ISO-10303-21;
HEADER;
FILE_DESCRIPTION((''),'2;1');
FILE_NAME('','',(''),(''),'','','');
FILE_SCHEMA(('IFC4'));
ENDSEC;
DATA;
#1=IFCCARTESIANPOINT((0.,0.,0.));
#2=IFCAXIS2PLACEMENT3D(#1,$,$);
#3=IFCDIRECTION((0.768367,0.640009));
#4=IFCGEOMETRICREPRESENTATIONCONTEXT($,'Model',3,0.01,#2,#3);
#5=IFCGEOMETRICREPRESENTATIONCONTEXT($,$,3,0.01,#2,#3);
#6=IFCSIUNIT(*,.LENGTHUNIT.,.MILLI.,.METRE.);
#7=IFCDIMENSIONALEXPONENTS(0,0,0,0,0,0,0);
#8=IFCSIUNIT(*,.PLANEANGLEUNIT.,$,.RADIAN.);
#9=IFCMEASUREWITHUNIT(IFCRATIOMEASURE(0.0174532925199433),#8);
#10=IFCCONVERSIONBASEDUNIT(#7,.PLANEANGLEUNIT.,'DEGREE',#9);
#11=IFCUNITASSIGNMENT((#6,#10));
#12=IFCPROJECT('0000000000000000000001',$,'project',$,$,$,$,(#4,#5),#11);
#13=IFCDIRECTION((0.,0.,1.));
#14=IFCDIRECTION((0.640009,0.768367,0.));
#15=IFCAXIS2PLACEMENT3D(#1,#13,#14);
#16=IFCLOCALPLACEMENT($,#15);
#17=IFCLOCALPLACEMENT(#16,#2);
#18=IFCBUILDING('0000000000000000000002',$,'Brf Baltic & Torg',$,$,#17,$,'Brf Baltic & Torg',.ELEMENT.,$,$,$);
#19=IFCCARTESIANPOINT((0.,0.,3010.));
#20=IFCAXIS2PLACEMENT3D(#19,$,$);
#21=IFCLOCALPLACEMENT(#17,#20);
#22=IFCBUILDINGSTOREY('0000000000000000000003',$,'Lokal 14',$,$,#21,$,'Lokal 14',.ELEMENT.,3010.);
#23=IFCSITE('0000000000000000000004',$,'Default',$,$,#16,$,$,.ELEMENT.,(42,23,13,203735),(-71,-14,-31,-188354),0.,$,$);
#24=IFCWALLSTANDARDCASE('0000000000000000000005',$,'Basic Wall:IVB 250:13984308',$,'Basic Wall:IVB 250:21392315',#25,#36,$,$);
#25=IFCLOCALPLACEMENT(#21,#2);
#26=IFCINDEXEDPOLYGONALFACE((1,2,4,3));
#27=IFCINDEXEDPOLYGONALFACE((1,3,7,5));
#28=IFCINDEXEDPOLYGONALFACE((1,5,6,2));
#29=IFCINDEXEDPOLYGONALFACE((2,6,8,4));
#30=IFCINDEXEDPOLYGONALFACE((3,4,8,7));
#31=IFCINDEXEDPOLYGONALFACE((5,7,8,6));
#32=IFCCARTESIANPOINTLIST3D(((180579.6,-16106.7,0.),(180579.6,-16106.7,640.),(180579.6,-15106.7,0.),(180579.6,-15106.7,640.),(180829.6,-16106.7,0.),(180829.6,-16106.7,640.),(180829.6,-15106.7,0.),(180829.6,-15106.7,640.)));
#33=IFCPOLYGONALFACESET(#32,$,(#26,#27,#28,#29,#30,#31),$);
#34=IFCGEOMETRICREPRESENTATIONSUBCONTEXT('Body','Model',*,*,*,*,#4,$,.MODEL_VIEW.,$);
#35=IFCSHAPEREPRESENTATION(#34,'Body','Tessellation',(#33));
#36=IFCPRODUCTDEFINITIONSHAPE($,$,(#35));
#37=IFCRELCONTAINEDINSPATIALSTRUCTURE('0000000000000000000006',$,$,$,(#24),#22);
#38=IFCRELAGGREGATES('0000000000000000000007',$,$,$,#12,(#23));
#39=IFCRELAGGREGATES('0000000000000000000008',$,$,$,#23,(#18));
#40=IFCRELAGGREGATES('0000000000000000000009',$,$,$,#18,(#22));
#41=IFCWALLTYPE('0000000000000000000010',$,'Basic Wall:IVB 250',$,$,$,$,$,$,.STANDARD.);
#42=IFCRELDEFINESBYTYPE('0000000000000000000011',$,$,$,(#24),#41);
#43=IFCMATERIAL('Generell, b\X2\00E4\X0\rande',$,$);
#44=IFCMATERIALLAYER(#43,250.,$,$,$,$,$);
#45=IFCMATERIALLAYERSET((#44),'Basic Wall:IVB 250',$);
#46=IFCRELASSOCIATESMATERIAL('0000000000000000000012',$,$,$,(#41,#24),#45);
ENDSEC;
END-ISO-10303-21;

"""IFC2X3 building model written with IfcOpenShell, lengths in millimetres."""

from ifc_helpers import new_model, entity, si_unit, converted_unit, direction, frame, frame_2d, origin, place, context, subcontext, project, spatial, rectangle, extrude, clip, halfspace, material, layer, layer_set, layer_usage, type_object, element, save


model = new_model("IFC2X3")

# Units and contexts
model_context = context("Model", 3, precision=0.01, world=origin(), true_north=direction((0.768367, 0.640009)))
context_of_model = context(None, 3, precision=0.01, world=origin(), true_north=direction((0.768367, 0.640009)))
body_context = subcontext(model_context, "Body", "Model", "MODEL_VIEW")
ifc_project = project(units=[si_unit("LENGTHUNIT", "METRE", prefix="MILLI"), converted_unit("PLANEANGLEUNIT", "DEGREE", entity("IfcRatioMeasure", 0.0174532925199433), si_unit("PLANEANGLEUNIT", "RADIAN"), dimensions=[0, 0, 0, 0, 0, 0, 0])], contexts=[model_context, context_of_model])

# Site, building, storey
site_placement = place(None, frame((0.0, 0.0, 0.0), z_axis=(0.0, 0.0, 1.0), x_axis=(0.640009, 0.768367, 0.0)))
site = spatial("IfcSite", under=ifc_project, at=site_placement, Name="Default", CompositionType="ELEMENT", RefLatitude=(42, 23, 13, 203735), RefLongitude=(-71, -14, -31, -188354), RefElevation=0.0)
building_placement = place(site_placement, origin())
building = spatial("IfcBuilding", under=site, at=building_placement, Name="Brf Baltic & Torg", LongName="Brf Baltic & Torg", CompositionType="ELEMENT")
storey_placement = place(building_placement, frame((0.0, 0.0, 3010.0)))
storey = spatial("IfcBuildingStorey", under=building, at=storey_placement, Name="Lokal 14", LongName="Lokal 14", CompositionType="ELEMENT", Elevation=3010.0)

# Shared definitions
ifc_material_1 = material(Name="Generell, bärande")

# Wall
ifc_layer_1 = layer(ifc_material_1, 250.0)
ifc_layer_set_1 = layer_set([ifc_layer_1], Name="Basic Wall:IVB 250")
ifc_layer_usage_1 = layer_usage(ifc_layer_set_1, "AXIS2", "NEGATIVE", 125.0)
wall_type_1 = type_object("IfcWallType", Name="Basic Wall:IVB 250", PredefinedType="STANDARD", material=ifc_layer_set_1)
wall_1_placement = place(storey_placement, frame((180704.6, -15106.7, 0.0), z_axis=(0.0, 0.0, 1.0), x_axis=(0.0, -1.0, 0.0)))
element("IfcWallStandardCase", 1, at=wall_1_placement, inside=storey, type_object=wall_type_1, material=ifc_layer_usage_1, Name="Basic Wall:IVB 250:13984308", ObjectType="Basic Wall:IVB 250:21392315", context=body_context, shape_type="Clipping", body=[
    clip(extrude(rectangle(XDim=1000.0, YDim=250.0, at=frame_2d((500.0, 0.0), x_axis=(-1.0, 0.0))), origin(), (0.0, 0.0, 1.0), 640.0), halfspace(frame((0.0, 0.0, -1360.0)), True)),
])

save(model, "model.ifc")
